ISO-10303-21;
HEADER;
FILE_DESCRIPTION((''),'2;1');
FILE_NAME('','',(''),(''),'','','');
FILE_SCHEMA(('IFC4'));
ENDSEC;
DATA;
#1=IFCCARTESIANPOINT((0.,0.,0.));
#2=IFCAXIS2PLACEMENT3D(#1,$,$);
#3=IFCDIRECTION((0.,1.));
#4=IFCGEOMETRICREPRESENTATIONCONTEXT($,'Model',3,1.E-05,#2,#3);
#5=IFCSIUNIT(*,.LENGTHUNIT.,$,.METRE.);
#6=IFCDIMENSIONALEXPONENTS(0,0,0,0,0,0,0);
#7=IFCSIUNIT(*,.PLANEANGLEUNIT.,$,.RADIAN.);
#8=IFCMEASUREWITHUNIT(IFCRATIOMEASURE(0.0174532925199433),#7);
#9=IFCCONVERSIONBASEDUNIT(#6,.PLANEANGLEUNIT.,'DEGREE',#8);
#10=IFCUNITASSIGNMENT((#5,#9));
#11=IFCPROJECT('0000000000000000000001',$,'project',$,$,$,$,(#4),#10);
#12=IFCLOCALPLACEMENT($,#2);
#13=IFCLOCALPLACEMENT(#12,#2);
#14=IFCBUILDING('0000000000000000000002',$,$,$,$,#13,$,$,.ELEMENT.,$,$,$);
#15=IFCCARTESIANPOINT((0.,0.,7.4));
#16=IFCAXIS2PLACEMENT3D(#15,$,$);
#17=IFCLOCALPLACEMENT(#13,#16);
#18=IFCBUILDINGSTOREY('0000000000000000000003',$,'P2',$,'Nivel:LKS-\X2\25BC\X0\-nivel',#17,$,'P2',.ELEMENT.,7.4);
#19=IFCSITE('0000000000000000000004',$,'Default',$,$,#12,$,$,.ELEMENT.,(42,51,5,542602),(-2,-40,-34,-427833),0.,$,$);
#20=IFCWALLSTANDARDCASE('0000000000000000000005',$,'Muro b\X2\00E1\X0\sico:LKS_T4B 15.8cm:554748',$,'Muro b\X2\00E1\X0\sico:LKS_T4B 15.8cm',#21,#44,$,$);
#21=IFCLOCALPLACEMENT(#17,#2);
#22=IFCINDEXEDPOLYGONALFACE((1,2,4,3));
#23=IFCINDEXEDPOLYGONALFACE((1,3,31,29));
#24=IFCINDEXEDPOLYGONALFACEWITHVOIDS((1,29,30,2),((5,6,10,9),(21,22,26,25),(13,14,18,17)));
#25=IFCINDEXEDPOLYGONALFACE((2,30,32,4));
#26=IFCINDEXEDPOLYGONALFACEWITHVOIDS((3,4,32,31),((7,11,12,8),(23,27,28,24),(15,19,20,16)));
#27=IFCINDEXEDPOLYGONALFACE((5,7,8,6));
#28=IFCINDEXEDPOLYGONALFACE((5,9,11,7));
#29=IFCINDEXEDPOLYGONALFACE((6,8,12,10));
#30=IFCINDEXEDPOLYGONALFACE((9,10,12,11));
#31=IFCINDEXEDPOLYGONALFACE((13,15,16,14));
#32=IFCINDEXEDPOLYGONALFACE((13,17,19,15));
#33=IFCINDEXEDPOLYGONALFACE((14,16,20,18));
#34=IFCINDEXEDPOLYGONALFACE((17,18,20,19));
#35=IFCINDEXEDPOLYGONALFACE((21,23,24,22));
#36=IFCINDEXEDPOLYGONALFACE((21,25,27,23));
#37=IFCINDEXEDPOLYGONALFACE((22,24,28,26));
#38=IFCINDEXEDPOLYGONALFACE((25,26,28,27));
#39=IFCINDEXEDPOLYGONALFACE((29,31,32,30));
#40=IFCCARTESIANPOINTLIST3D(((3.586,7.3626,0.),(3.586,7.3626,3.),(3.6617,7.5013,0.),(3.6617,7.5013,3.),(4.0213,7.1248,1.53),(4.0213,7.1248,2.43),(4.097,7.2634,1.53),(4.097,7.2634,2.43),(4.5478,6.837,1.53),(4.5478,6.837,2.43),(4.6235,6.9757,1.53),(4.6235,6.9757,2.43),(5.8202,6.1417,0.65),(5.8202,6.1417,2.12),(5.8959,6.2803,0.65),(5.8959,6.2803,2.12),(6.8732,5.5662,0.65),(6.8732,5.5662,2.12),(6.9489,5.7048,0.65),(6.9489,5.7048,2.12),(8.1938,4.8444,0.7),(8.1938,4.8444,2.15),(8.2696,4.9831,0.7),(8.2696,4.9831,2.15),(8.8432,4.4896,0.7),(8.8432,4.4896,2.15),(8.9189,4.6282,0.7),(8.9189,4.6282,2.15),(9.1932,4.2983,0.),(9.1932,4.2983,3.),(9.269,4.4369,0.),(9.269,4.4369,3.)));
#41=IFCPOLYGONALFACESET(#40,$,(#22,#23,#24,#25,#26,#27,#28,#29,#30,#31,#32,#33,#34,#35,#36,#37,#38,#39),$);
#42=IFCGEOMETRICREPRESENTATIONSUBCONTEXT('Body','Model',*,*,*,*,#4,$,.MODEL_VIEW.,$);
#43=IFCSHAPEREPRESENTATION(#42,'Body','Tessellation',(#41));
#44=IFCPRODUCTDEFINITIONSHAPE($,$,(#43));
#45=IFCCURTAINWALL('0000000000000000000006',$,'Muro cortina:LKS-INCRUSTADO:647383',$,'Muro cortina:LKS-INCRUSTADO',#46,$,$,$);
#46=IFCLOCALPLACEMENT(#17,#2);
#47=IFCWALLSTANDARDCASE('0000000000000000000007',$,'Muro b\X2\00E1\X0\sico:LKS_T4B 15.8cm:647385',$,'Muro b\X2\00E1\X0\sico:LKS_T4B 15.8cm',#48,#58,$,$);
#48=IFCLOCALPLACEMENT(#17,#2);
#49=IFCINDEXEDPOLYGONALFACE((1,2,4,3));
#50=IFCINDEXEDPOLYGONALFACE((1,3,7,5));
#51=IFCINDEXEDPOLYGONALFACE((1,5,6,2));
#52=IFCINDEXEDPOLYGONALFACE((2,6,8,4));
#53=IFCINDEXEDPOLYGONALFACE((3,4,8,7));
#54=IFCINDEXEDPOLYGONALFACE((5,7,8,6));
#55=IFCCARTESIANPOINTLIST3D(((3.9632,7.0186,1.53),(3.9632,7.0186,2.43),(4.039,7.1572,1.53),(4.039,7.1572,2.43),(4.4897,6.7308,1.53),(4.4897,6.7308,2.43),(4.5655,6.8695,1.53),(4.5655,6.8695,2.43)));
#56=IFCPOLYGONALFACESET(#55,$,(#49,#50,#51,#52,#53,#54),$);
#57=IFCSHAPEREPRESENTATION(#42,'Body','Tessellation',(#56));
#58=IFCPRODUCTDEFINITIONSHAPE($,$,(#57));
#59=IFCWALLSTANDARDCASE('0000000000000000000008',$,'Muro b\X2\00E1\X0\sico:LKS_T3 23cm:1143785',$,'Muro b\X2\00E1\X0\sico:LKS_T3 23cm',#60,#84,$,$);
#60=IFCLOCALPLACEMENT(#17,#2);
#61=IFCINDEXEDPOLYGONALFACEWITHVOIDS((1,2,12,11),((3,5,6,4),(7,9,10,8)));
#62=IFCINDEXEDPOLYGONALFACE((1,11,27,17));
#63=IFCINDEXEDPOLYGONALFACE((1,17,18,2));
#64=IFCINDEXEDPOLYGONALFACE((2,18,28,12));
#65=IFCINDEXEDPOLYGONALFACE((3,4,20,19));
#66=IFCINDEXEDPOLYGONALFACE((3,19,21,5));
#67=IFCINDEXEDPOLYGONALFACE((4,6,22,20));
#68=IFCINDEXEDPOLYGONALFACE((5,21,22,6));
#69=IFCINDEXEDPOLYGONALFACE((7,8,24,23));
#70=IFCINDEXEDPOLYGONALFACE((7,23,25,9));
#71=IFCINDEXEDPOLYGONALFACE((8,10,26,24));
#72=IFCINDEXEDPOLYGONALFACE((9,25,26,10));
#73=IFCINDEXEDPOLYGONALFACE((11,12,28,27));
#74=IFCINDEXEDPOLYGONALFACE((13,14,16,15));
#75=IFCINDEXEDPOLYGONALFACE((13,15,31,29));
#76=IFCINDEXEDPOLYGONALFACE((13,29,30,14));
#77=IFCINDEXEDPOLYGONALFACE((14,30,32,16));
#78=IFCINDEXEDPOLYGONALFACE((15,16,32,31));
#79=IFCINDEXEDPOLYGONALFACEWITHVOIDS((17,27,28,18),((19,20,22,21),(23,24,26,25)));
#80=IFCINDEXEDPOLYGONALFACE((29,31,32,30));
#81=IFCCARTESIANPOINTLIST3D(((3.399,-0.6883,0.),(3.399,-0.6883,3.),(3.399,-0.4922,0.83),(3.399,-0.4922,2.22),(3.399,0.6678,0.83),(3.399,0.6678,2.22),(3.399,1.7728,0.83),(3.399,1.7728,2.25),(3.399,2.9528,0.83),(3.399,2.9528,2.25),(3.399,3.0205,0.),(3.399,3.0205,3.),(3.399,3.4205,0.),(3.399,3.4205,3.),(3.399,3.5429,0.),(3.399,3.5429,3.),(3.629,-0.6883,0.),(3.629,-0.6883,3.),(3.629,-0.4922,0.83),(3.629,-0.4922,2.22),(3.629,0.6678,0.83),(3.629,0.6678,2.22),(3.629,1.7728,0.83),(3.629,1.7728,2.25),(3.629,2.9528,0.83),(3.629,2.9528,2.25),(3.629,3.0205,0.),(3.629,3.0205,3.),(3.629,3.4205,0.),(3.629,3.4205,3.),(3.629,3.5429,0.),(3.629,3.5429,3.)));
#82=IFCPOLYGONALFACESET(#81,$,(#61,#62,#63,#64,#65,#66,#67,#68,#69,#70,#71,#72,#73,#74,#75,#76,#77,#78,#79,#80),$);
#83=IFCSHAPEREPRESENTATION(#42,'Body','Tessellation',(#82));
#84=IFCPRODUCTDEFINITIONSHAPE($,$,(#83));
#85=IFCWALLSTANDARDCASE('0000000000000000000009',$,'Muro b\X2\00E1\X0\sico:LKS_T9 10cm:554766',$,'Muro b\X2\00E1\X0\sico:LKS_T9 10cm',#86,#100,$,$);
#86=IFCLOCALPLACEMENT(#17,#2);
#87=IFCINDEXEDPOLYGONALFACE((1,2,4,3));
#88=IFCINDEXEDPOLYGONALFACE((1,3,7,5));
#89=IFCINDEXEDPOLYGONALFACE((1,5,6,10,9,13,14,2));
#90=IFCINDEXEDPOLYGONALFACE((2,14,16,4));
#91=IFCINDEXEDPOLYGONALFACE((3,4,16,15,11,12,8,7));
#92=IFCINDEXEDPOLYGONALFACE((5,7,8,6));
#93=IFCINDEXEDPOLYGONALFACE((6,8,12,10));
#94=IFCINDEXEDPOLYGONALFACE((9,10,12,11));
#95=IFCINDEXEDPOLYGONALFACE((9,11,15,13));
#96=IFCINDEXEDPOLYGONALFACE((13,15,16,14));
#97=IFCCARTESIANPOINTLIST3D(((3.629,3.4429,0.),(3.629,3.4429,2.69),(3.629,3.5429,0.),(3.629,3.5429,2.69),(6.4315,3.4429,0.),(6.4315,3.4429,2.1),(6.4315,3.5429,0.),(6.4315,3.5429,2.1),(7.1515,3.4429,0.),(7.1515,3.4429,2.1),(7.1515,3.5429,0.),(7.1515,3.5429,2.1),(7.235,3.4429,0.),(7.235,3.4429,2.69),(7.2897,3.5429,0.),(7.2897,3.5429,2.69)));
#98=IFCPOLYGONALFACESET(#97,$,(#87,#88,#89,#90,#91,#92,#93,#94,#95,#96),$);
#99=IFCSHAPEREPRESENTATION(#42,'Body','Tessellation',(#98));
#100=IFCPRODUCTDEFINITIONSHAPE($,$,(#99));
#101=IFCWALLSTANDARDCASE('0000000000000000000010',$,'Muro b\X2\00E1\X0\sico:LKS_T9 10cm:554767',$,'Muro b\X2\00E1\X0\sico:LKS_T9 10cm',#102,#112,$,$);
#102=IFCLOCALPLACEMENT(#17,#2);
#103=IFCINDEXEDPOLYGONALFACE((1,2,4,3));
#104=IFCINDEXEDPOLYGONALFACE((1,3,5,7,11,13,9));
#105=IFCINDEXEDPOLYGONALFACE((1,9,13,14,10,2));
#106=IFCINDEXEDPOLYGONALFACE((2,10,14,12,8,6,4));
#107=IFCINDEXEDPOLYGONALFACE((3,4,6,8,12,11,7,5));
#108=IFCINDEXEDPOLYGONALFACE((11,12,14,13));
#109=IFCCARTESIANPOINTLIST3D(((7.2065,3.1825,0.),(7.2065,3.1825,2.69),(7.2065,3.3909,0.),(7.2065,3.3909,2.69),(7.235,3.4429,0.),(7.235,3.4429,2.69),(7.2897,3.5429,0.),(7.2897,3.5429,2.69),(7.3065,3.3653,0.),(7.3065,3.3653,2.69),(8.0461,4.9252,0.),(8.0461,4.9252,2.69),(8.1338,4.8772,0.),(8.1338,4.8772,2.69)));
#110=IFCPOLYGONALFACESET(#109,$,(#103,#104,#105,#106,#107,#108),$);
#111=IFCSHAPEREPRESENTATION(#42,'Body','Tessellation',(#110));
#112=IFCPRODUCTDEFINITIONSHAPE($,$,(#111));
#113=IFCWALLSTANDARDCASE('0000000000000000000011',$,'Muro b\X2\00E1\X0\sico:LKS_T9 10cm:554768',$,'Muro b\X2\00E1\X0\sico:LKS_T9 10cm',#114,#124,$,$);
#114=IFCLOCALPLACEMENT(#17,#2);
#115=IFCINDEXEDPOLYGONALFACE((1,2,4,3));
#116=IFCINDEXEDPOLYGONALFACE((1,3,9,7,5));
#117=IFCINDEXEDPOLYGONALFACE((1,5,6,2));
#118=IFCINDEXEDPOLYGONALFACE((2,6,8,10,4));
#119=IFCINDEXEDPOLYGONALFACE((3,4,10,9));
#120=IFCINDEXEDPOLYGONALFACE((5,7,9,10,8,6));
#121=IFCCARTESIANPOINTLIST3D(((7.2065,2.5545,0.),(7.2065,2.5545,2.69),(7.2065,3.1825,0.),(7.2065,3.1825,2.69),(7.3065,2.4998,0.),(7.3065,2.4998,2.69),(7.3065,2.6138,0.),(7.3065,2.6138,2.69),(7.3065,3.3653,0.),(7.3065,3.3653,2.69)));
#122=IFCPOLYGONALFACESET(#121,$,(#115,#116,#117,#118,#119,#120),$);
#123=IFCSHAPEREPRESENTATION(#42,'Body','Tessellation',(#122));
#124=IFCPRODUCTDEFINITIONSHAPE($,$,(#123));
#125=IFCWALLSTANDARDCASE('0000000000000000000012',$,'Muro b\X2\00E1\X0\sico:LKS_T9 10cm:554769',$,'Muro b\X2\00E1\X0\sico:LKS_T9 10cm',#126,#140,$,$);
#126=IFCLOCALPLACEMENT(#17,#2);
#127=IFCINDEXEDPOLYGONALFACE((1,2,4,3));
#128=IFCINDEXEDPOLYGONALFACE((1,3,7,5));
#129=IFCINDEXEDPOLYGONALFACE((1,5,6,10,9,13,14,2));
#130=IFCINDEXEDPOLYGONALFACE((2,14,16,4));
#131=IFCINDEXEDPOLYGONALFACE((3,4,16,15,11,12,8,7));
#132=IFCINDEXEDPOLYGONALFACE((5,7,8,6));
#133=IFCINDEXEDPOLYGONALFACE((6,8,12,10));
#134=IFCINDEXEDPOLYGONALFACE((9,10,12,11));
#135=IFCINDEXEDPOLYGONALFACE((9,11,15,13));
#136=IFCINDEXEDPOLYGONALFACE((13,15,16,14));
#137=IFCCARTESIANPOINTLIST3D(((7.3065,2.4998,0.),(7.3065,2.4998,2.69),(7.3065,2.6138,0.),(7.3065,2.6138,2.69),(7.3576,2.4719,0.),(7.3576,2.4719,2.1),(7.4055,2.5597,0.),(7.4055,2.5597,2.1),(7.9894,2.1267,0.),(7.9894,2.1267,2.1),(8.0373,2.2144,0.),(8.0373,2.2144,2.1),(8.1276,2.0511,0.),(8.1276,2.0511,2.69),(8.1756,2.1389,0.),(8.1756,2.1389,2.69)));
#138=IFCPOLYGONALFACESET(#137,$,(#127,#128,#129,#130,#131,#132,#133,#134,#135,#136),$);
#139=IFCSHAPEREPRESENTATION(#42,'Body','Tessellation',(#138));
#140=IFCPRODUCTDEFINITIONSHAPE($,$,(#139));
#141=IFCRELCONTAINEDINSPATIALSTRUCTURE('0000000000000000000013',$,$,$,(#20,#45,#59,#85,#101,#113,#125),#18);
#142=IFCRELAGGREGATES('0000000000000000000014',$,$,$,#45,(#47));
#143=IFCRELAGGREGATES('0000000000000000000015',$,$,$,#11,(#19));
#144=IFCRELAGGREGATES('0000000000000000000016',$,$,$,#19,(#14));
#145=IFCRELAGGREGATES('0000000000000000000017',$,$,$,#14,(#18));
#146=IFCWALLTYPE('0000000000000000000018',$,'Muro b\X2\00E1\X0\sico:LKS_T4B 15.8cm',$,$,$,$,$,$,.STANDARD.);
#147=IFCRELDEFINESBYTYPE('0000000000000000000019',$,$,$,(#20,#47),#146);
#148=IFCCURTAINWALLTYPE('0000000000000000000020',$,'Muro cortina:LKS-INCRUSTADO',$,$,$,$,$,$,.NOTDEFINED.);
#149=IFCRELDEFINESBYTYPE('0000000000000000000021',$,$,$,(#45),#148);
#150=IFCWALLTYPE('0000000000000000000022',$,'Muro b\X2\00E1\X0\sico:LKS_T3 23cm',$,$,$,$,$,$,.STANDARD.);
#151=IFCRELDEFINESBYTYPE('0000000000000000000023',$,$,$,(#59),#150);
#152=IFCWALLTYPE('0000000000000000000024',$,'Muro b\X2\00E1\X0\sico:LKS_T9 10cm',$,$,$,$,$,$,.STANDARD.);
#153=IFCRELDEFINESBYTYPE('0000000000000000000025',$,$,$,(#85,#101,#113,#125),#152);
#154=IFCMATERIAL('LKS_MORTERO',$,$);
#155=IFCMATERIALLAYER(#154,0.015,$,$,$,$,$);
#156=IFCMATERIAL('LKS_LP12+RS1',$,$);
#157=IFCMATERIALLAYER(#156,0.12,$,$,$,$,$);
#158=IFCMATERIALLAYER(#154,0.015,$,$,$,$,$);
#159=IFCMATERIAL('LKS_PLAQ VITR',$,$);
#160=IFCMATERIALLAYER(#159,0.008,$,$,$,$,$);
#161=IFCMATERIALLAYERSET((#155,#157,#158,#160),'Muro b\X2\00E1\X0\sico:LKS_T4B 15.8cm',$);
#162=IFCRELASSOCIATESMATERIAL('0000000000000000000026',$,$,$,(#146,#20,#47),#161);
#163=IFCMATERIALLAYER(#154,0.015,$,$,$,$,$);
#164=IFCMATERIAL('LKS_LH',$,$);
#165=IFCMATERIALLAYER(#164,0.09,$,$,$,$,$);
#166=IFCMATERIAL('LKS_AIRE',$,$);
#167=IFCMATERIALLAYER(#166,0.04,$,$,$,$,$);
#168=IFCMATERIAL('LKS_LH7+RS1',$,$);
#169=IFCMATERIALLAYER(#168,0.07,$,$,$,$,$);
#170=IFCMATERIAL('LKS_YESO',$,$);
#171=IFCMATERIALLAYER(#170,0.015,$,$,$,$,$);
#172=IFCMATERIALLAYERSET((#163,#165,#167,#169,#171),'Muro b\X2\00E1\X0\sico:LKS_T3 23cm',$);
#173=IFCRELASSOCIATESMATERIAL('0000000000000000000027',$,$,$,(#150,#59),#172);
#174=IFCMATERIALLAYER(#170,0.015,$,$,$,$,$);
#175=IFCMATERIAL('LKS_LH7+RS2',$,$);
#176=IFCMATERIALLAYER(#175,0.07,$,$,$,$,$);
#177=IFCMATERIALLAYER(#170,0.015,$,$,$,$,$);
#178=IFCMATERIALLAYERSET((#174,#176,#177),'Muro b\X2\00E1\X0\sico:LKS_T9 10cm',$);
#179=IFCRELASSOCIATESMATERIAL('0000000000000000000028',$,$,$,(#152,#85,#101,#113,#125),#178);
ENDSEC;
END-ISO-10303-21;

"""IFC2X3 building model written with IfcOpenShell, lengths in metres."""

from ifc_helpers import new_model, entity, si_unit, converted_unit, direction, frame, frame_2d, origin, place, context, subcontext, project, spatial, polyline, rectangle, outline, extrude, clip, bounded_halfspace, material, layer, layer_set, layer_usage, type_object, element, aggregate, save


model = new_model("IFC2X3")

# Units and contexts
model_context = context("Model", 3, precision=1e-05, world=origin(), true_north=direction((0.0, 1.0)))
body_context = subcontext(model_context, "Body", "Model", "MODEL_VIEW")
ifc_project = project(units=[si_unit("LENGTHUNIT", "METRE"), converted_unit("PLANEANGLEUNIT", "DEGREE", entity("IfcRatioMeasure", 0.0174532925199433), si_unit("PLANEANGLEUNIT", "RADIAN"), dimensions=[0, 0, 0, 0, 0, 0, 0])], contexts=[model_context])

# Site, building, storey
site_placement = place(None, origin())
site = spatial("IfcSite", under=ifc_project, at=site_placement, Name="Default", CompositionType="ELEMENT", RefLatitude=(42, 51, 5, 542602), RefLongitude=(-2, -40, -34, -427833), RefElevation=0.0)
building_placement = place(site_placement, origin())
building = spatial("IfcBuilding", under=site, at=building_placement, CompositionType="ELEMENT")
storey_placement = place(building_placement, frame((0.0, 0.0, 7.4)))
storey = spatial("IfcBuildingStorey", under=building, at=storey_placement, Name="P2", ObjectType="Nivel:LKS-▼-nivel", LongName="P2", CompositionType="ELEMENT", Elevation=7.4)

# Shared definitions
ifc_material_1 = material(Name="LKS_MORTERO")
ifc_layer_1 = layer(ifc_material_1, 0.015)
ifc_material_2 = material(Name="LKS_LP12+RS1")
ifc_layer_2 = layer(ifc_material_2, 0.12)
ifc_layer_3 = layer(ifc_material_1, 0.015)
ifc_material_3 = material(Name="LKS_PLAQ VITR")
ifc_layer_4 = layer(ifc_material_3, 0.008)
ifc_layer_set_1 = layer_set([ifc_layer_1, ifc_layer_2, ifc_layer_3, ifc_layer_4], Name="Muro básico:LKS_T4B 15.8cm")
wall_type_1 = type_object("IfcWallType", Name="Muro básico:LKS_T4B 15.8cm", PredefinedType="STANDARD", material=ifc_layer_set_1)

# Wall, openings
ifc_layer_usage_1 = layer_usage(ifc_layer_set_1, "AXIS2", "POSITIVE", -0.079)
wall_1_placement = place(storey_placement, frame((9.2311, 4.3676, 0.0), z_axis=(0.0, 0.0, 1.0), x_axis=(-0.877509, 0.479561, 0.0)))
wall_1 = element("IfcWallStandardCase", 1, at=wall_1_placement, inside=storey, type_object=wall_type_1, material=ifc_layer_usage_1, Name="Muro básico:LKS_T4B 15.8cm:554748", ObjectType="Muro básico:LKS_T4B 15.8cm", context=body_context, shape_type="Clipping", body=[
    clip(clip(extrude(rectangle(XDim=6.39, YDim=0.158, at=frame_2d((3.195, 0.0), x_axis=(-1.0, 0.0))), origin(), (0.0, 0.0, 1.0), 3.0), bounded_halfspace(frame((0.0, -0.079, 0.0), z_axis=(1.0, 0.0, 0.0), x_axis=(0.0, 0.0, -1.0)), True, frame((0.0, -0.079, 0.0), z_axis=(1.0, 0.0, 0.0), x_axis=(0.0, 0.0, -1.0)), polyline([(0.0, 0.0), (0.0, 0.158), (-3.0, 0.158), (-3.0, 0.0488), (-3.0, 0.0), (0.0, 0.0)]))), bounded_halfspace(frame((6.39, -0.079, 3.0), z_axis=(-1.0, 0.0, 0.0), x_axis=(0.0, 0.0, -1.0)), True, frame((6.39, -0.079, 3.0), z_axis=(-1.0, 0.0, 0.0), x_axis=(0.0, 0.0, -1.0)), polyline([(0.0, 0.0), (0.0, -0.0455), (0.0, -0.158), (3.0, -0.158), (3.0, 0.0), (0.0, 0.0)]))),
])
opening_1_placement = place(wall_1_placement, origin())
element("IfcOpeningElement", 2, at=opening_1_placement, cuts=wall_1, ObjectType="Opening", context=body_context, shape_type="SweptSolid", body=[
    extrude(rectangle(XDim=0.9, YDim=0.6, at=frame_2d((0.0, 0.0), x_axis=(0.0, 1.0))), frame((5.5939, -0.2314, 1.98), z_axis=(0.0, 1.0, 0.0), x_axis=(-1.0, 0.0, 0.0)), (0.0, 0.0, 1.0), 0.4628),
])
opening_2_placement = place(wall_1_placement, frame((3.8439, 0.079, 0.65)))
element("IfcOpeningElement", 3, at=opening_2_placement, cuts=wall_1, ObjectType="Opening", context=body_context, shape_type="SweptSolid", body=[
    extrude(rectangle(XDim=1.47, YDim=1.2, at=frame_2d((0.735, 0.6), x_axis=(1.0, 0.0))), frame((0.0, 0.0, 0.0), z_axis=(0.0, -1.0, 0.0), x_axis=(0.0, 0.0, 1.0)), (0.0, 0.0, 1.0), 0.158),
])
opening_3_placement = place(wall_1_placement, frame((1.1389, 0.079, 0.7)))
element("IfcOpeningElement", 4, at=opening_3_placement, cuts=wall_1, ObjectType="Opening", context=body_context, shape_type="SweptSolid", body=[
    extrude(rectangle(XDim=1.45, YDim=0.74, at=frame_2d((0.725, 0.37), x_axis=(1.0, 0.0))), frame((0.0, 0.0, 0.0), z_axis=(0.0, -1.0, 0.0), x_axis=(0.0, 0.0, 1.0)), (0.0, 0.0, 1.0), 0.158),
])

# Curtain wall, wall
curtain_wall_type = type_object("IfcCurtainWallType", Name="Muro cortina:LKS-INCRUSTADO", PredefinedType="NOTDEFINED")
curtain_wall_placement = place(storey_placement, frame((0.0, 0.0, -7.4)))
curtain_wall = element("IfcCurtainWall", 5, at=curtain_wall_placement, inside=storey, type_object=curtain_wall_type, Name="Muro cortina:LKS-INCRUSTADO:647383", ObjectType="Muro cortina:LKS-INCRUSTADO")
ifc_layer_usage_2 = layer_usage(ifc_layer_set_1, "AXIS2", "NEGATIVE", 0.079)
wall_2_placement = place(storey_placement, frame((4.0011, 7.0879, 1.53), z_axis=(0.0, 0.0, 1.0), x_axis=(0.877509, -0.479561, 0.0)))
wall_2 = element("IfcWallStandardCase", 6, at=wall_2_placement, type_object=wall_type_1, material=ifc_layer_usage_2, Name="Muro básico:LKS_T4B 15.8cm:647385", ObjectType="Muro básico:LKS_T4B 15.8cm", context=body_context, shape_type="SweptSolid", body=[
    extrude(rectangle(XDim=0.6, YDim=0.158, at=frame_2d((0.3, 0.0), x_axis=(-1.0, 0.0))), origin(), (0.0, 0.0, 1.0), 0.9),
])
aggregate(curtain_wall, [wall_2])

# Wall, openings
ifc_layer_5 = layer(ifc_material_1, 0.015)
ifc_material_4 = material(Name="LKS_LH")
ifc_layer_6 = layer(ifc_material_4, 0.09)
ifc_material_5 = material(Name="LKS_AIRE")
ifc_layer_7 = layer(ifc_material_5, 0.04)
ifc_material_6 = material(Name="LKS_LH7+RS1")
ifc_layer_8 = layer(ifc_material_6, 0.07)
ifc_material_7 = material(Name="LKS_YESO")
ifc_layer_9 = layer(ifc_material_7, 0.015)
ifc_layer_set_2 = layer_set([ifc_layer_5, ifc_layer_6, ifc_layer_7, ifc_layer_8, ifc_layer_9], Name="Muro básico:LKS_T3 23cm")
ifc_layer_usage_3 = layer_usage(ifc_layer_set_2, "AXIS2", "POSITIVE", -0.115)
wall_type_2 = type_object("IfcWallType", Name="Muro básico:LKS_T3 23cm", PredefinedType="STANDARD", material=ifc_layer_set_2)
wall_3_placement = place(storey_placement, frame((3.514, 3.5429, 0.0), z_axis=(0.0, 0.0, 1.0), x_axis=(0.0, -1.0, 0.0)))
wall_3 = element("IfcWallStandardCase", 7, at=wall_3_placement, inside=storey, type_object=wall_type_2, material=ifc_layer_usage_3, Name="Muro básico:LKS_T3 23cm:1143785", ObjectType="Muro básico:LKS_T3 23cm", context=body_context, shape_type="SweptSolid", body=[
    extrude(rectangle(XDim=4.2311, YDim=0.23, at=frame_2d((2.1156, 0.0), x_axis=(-1.0, 0.0))), origin(), (0.0, 0.0, 1.0), 3.0),
])
opening_4_placement = place(storey_placement, frame((3.514, 3.5429, 0.0), z_axis=(0.0, 0.0, 1.0), x_axis=(0.0, -1.0, 0.0)))
element("IfcOpeningElement", 8, at=opening_4_placement, cuts=wall_3, ObjectType="Opening", context=body_context, shape_type="SweptSolid", body=[
    extrude(rectangle(XDim=3.0, YDim=0.23, at=frame_2d((-0.3, 0.013), x_axis=(1.0, 0.0))), frame((0.5224, -0.013, 1.8), z_axis=(-1.0, 0.0, 0.0), x_axis=(0.0, 0.0, 1.0)), (0.0, 0.0, 1.0), 0.4),
])
opening_5_placement = place(wall_3_placement, frame((4.0351, 0.115, 0.83)))
element("IfcOpeningElement", 9, at=opening_5_placement, cuts=wall_3, ObjectType="Opening", context=body_context, shape_type="SweptSolid", body=[
    extrude(rectangle(XDim=1.39, YDim=1.16, at=frame_2d((0.695, 0.58), x_axis=(1.0, 0.0))), frame((0.0, 0.0, 0.0), z_axis=(0.0, -1.0, 0.0), x_axis=(0.0, 0.0, 1.0)), (0.0, 0.0, 1.0), 0.23),
])
opening_6_placement = place(wall_3_placement, frame((0.5901, -0.115, 0.83)))
element("IfcOpeningElement", 10, at=opening_6_placement, cuts=wall_3, ObjectType="Opening", context=body_context, shape_type="SweptSolid", body=[
    extrude(rectangle(XDim=1.42, YDim=1.18, at=frame_2d((0.71, 0.59), x_axis=(1.0, 0.0))), frame((0.0, 0.0, 0.0), z_axis=(0.0, 1.0, 0.0), x_axis=(0.0, 0.0, 1.0)), (0.0, 0.0, 1.0), 0.23),
])

# Wall, opening
ifc_layer_10 = layer(ifc_material_7, 0.015)
ifc_material_8 = material(Name="LKS_LH7+RS2")
ifc_layer_11 = layer(ifc_material_8, 0.07)
ifc_layer_12 = layer(ifc_material_7, 0.015)
ifc_layer_set_3 = layer_set([ifc_layer_10, ifc_layer_11, ifc_layer_12], Name="Muro básico:LKS_T9 10cm")
ifc_layer_usage_4 = layer_usage(ifc_layer_set_3, "AXIS2", "NEGATIVE", 0.05)
wall_type_3 = type_object("IfcWallType", Name="Muro básico:LKS_T9 10cm", PredefinedType="STANDARD", material=ifc_layer_set_3)
wall_4_placement = place(storey_placement, frame((7.2897, 3.4929, 0.0), z_axis=(0.0, 0.0, 1.0), x_axis=(-1.0, 0.0, 0.0)))
wall_4 = element("IfcWallStandardCase", 11, at=wall_4_placement, inside=storey, type_object=wall_type_3, material=ifc_layer_usage_4, Name="Muro básico:LKS_T9 10cm:554766", ObjectType="Muro básico:LKS_T9 10cm", context=body_context, shape_type="SweptSolid", body=[
    extrude(outline(polyline([(0.0, -0.05), (3.6608, -0.05), (3.6608, 0.05), (1.0132, 0.05), (0.9132, 0.05), (0.0547, 0.05), (0.0, -0.05)])), origin(), (0.0, 0.0, 1.0), 2.69),
])
opening_7_placement = place(wall_4_placement, frame((0.8582, 0.05, 0.0)))
element("IfcOpeningElement", 12, at=opening_7_placement, cuts=wall_4, ObjectType="Opening", context=body_context, shape_type="SweptSolid", body=[
    extrude(rectangle(XDim=2.1, YDim=0.72, at=frame_2d((1.05, 0.36), x_axis=(1.0, 0.0))), frame((0.0, 0.0, 0.0), z_axis=(0.0, -1.0, 0.0), x_axis=(0.0, 0.0, 1.0)), (0.0, 0.0, 1.0), 0.1),
])

# Walls
ifc_layer_usage_5 = layer_usage(ifc_layer_set_3, "AXIS2", "NEGATIVE", 0.05)
wall_5_placement = place(storey_placement, frame((8.09, 4.9012, 0.0), z_axis=(0.0, 0.0, 1.0), x_axis=(-0.480022, -0.877256, 0.0)))
element("IfcWallStandardCase", 13, at=wall_5_placement, inside=storey, type_object=wall_type_3, material=ifc_layer_usage_5, Name="Muro básico:LKS_T9 10cm:554767", ObjectType="Muro básico:LKS_T9 10cm", context=body_context, shape_type="SweptSolid", body=[
    extrude(outline(polyline([(1.749, -0.05), (1.9318, 0.05), (1.7235, 0.05), (0.0, 0.05), (0.0001, -0.05), (1.5758, -0.05), (1.6897, -0.05), (1.749, -0.05)])), origin(), (0.0, 0.0, 1.0), 2.69),
])
ifc_layer_usage_6 = layer_usage(ifc_layer_set_3, "AXIS2", "NEGATIVE", 0.05)
wall_6_placement = place(storey_placement, frame((7.2565, 3.3653, 0.0), z_axis=(0.0, 0.0, 1.0), x_axis=(0.0, -1.0, 0.0)))
element("IfcWallStandardCase", 14, at=wall_6_placement, inside=storey, type_object=wall_type_3, material=ifc_layer_usage_6, Name="Muro básico:LKS_T9 10cm:554768", ObjectType="Muro básico:LKS_T9 10cm", context=body_context, shape_type="SweptSolid", body=[
    extrude(outline(polyline([(0.8108, -0.05), (0.8655, 0.05), (0.7515, 0.05), (0.0, 0.05), (0.1828, -0.05), (0.8108, -0.05)])), origin(), (0.0, 0.0, 1.0), 2.69),
])

# Wall, opening
ifc_layer_usage_7 = layer_usage(ifc_layer_set_3, "AXIS2", "NEGATIVE", 0.05)
wall_7_placement = place(storey_placement, frame((7.2826, 2.5699, 0.0), z_axis=(0.0, 0.0, 1.0), x_axis=(0.877509, -0.479561, 0.0)))
wall_7 = element("IfcWallStandardCase", 15, at=wall_7_placement, inside=storey, type_object=wall_type_3, material=ifc_layer_usage_7, Name="Muro básico:LKS_T9 10cm:554769", ObjectType="Muro básico:LKS_T9 10cm", context=body_context, shape_type="SweptSolid", body=[
    extrude(outline(polyline([(0.0547, -0.05), (0.9903, -0.05), (0.9903, 0.05), (0.0, 0.05), (0.0547, -0.05)])), origin(), (0.0, 0.0, 1.0), 2.69),
])
opening_8_placement = place(wall_7_placement, frame((0.1128, -0.05, 0.0)))
element("IfcOpeningElement", 16, at=opening_8_placement, cuts=wall_7, ObjectType="Opening", context=body_context, shape_type="SweptSolid", body=[
    extrude(rectangle(XDim=2.1, YDim=0.72, at=frame_2d((1.05, 0.36), x_axis=(1.0, 0.0))), frame((0.0, 0.0, 0.0), z_axis=(0.0, 1.0, 0.0), x_axis=(0.0, 0.0, 1.0)), (0.0, 0.0, 1.0), 0.1),
])

save(model, "model.ifc")
